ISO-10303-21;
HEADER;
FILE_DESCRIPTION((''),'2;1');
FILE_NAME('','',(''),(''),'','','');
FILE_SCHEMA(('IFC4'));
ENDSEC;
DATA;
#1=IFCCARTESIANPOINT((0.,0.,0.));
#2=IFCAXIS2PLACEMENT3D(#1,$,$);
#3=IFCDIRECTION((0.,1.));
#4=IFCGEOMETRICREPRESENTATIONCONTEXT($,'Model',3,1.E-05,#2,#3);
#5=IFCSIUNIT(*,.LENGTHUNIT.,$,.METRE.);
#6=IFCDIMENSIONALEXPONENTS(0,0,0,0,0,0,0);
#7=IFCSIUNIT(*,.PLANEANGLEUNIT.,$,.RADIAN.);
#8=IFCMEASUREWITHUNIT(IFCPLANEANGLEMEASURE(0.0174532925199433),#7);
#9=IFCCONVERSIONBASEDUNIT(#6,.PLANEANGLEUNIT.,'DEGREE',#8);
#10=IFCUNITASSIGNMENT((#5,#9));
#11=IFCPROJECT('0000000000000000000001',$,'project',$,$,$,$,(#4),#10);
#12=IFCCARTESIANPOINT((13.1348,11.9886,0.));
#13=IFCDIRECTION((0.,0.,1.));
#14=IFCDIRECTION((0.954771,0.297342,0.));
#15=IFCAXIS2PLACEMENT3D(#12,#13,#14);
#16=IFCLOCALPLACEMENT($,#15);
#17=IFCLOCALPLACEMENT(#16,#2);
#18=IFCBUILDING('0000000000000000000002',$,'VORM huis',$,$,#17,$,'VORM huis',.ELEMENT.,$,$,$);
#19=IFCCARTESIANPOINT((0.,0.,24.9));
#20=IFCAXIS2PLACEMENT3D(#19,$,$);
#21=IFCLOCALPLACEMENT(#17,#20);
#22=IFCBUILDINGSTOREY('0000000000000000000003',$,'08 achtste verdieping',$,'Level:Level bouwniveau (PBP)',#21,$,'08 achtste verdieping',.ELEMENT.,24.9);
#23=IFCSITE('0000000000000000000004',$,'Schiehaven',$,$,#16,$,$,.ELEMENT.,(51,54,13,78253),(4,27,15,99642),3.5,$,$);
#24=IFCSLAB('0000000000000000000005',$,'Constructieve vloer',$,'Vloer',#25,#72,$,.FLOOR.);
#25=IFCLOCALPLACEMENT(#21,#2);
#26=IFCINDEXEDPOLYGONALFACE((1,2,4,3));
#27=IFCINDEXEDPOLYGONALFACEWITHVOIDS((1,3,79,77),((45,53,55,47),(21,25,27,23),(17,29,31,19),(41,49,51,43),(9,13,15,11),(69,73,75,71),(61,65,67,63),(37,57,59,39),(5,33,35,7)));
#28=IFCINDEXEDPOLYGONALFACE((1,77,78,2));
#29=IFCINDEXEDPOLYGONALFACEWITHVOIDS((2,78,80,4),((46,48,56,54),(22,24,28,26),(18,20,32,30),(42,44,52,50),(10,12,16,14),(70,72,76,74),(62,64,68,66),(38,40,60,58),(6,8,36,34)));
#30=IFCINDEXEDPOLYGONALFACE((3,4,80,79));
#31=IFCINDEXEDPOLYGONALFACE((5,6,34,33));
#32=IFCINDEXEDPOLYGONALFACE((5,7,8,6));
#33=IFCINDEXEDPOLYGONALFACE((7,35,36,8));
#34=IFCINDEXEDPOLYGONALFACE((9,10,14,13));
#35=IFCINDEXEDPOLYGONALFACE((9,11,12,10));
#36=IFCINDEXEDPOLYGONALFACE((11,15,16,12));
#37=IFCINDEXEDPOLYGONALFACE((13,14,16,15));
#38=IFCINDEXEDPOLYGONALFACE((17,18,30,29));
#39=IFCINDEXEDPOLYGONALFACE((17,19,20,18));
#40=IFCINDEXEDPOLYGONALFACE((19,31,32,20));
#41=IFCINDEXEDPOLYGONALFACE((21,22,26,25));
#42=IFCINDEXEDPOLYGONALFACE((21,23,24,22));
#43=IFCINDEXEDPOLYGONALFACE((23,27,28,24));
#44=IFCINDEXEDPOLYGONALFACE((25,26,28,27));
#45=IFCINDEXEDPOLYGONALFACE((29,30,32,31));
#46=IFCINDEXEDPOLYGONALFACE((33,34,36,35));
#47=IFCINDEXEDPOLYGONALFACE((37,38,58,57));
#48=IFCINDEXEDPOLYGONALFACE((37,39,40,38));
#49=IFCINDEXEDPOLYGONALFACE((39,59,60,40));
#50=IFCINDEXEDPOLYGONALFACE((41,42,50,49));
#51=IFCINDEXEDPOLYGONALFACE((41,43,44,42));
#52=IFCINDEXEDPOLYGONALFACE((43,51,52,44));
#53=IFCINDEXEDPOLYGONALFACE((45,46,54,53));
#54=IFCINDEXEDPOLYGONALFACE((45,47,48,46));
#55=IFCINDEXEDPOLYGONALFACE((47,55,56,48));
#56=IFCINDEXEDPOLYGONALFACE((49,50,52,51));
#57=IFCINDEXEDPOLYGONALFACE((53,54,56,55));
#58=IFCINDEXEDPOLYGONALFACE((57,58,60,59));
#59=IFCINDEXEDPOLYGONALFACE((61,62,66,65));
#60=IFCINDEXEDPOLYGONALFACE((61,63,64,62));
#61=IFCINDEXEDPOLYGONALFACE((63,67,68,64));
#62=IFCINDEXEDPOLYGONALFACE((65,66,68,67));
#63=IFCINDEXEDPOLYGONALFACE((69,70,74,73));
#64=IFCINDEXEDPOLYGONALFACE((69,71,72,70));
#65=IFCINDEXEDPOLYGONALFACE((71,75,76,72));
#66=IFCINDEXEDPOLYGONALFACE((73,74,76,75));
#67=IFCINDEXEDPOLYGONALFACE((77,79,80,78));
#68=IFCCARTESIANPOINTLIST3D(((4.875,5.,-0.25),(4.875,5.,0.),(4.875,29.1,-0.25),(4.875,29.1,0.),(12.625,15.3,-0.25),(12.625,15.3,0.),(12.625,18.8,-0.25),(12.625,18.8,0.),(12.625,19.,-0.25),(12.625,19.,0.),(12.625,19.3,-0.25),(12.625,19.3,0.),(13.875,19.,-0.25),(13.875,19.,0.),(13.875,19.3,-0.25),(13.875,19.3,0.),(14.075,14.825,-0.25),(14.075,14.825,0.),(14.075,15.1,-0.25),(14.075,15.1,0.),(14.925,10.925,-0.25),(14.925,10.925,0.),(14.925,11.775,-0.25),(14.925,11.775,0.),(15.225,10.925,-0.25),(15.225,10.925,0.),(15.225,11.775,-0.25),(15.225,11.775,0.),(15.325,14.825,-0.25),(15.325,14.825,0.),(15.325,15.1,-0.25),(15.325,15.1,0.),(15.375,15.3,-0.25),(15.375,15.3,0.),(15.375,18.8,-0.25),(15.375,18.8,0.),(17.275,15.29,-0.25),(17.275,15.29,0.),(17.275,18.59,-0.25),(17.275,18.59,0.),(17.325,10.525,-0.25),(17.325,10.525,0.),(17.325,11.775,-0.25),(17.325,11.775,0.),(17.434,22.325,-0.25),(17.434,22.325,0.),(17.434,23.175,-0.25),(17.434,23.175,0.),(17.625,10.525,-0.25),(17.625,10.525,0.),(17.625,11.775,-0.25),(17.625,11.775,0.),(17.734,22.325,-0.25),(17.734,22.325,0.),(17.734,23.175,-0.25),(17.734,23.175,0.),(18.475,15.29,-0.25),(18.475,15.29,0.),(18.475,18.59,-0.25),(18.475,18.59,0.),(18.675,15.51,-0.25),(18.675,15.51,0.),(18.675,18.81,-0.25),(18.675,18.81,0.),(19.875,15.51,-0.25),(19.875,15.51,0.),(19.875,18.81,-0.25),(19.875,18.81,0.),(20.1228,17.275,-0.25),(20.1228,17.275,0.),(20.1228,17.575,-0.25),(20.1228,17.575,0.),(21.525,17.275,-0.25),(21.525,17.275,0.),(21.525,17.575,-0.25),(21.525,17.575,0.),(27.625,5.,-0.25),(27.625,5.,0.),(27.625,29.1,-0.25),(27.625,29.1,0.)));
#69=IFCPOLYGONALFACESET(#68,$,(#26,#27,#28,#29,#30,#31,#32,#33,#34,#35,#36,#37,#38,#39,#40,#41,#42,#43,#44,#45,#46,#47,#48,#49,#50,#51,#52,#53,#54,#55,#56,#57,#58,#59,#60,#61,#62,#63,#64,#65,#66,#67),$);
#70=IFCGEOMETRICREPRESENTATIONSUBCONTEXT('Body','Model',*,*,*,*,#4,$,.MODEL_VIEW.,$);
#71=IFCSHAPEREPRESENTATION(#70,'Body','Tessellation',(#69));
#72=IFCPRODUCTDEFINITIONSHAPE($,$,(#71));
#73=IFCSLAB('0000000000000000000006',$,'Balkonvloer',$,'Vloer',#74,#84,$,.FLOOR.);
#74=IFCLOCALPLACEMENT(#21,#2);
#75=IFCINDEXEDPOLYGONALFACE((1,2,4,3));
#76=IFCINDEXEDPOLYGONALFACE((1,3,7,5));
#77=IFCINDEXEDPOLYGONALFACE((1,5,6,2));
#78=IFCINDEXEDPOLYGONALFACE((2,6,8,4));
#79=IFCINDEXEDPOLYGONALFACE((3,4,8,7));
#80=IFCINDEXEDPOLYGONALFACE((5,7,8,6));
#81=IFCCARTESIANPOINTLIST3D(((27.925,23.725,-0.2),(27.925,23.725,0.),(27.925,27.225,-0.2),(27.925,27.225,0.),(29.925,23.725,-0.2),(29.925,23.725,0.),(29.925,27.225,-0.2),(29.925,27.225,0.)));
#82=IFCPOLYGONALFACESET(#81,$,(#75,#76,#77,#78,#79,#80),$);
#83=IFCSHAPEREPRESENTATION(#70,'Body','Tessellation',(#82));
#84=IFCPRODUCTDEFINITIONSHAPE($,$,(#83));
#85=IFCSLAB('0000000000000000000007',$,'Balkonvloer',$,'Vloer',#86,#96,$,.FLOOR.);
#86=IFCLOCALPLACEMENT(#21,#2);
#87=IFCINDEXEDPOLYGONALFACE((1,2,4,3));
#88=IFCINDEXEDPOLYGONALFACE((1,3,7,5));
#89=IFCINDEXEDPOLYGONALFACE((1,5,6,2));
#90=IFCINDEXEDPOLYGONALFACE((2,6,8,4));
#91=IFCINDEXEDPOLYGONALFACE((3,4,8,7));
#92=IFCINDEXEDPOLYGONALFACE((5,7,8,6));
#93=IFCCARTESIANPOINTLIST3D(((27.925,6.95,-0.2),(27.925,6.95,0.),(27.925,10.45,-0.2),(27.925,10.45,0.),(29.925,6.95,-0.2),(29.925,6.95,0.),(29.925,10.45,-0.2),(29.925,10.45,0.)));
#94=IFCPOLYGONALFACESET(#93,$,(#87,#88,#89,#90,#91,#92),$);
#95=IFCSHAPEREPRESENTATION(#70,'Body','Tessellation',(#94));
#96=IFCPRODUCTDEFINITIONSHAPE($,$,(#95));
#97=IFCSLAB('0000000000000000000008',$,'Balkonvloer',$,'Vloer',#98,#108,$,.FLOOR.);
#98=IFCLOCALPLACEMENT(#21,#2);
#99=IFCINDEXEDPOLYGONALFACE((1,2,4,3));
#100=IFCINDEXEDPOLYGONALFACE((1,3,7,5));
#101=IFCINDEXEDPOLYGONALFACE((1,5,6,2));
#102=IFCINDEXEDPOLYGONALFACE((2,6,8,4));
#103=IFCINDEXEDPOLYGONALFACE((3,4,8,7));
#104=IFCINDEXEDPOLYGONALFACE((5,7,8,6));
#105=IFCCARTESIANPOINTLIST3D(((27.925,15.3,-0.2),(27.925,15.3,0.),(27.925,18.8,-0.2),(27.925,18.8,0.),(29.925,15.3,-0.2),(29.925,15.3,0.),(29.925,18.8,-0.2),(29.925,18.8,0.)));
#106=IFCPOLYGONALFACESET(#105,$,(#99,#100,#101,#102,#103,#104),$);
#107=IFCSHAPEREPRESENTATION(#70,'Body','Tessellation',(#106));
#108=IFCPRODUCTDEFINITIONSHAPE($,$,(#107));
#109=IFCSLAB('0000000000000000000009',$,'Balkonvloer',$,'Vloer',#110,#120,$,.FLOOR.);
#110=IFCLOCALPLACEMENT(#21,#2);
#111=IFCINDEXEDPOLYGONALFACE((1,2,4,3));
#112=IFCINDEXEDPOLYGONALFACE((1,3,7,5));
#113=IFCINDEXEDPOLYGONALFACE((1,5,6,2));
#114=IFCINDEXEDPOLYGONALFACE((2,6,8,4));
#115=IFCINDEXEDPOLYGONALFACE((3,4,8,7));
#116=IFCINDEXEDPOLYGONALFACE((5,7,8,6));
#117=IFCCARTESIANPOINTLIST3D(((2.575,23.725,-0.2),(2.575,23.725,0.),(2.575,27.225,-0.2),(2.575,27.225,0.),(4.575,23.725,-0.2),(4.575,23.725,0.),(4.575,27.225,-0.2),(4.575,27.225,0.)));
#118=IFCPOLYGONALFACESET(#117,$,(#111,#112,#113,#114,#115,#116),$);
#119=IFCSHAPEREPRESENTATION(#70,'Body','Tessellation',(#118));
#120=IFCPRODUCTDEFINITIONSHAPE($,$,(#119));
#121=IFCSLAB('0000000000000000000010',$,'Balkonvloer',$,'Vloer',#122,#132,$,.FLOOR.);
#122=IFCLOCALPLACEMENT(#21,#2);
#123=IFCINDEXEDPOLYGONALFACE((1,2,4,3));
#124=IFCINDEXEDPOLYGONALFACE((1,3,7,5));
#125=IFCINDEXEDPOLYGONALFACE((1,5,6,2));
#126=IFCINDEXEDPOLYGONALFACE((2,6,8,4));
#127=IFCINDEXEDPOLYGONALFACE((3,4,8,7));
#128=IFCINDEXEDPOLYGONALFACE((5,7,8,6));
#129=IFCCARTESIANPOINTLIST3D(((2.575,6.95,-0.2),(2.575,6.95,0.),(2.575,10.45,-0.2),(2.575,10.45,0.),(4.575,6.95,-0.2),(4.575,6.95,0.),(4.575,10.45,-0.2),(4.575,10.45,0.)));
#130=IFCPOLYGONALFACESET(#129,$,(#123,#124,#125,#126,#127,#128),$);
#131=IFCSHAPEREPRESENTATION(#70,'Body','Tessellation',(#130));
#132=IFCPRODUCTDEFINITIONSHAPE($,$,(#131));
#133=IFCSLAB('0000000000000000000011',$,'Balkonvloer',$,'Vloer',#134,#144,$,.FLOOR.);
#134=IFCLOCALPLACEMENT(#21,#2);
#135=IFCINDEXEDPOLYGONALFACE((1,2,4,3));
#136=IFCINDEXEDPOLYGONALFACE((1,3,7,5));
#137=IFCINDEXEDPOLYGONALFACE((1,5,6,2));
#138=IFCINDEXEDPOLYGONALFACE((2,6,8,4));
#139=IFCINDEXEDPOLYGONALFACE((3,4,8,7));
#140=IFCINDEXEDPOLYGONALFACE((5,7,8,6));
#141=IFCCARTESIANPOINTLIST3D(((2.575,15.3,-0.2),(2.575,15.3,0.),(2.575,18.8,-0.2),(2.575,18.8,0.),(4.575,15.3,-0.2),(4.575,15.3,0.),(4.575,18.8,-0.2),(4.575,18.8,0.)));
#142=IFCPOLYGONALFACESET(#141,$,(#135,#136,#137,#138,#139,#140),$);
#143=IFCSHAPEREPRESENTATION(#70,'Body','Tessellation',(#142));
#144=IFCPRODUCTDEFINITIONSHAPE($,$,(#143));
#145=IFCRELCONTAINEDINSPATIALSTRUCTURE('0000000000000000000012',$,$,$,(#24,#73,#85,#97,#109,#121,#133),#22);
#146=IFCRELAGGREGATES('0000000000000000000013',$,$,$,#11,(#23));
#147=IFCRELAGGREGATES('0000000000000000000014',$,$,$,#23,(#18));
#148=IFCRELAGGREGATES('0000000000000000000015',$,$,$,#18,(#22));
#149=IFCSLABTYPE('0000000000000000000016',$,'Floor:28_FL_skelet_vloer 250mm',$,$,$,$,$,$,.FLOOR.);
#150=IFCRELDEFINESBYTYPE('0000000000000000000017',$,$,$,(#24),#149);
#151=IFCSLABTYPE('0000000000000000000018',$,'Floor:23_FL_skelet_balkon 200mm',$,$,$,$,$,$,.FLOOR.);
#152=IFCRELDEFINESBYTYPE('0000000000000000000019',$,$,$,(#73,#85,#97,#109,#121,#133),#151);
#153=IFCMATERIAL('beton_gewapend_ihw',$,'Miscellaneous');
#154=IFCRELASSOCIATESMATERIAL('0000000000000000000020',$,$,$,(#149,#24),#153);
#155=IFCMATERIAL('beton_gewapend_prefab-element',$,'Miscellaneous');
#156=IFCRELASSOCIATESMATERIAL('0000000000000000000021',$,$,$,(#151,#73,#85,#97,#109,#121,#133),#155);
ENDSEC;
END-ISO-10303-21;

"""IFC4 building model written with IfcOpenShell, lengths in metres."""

from ifc_helpers import new_model, entity, si_unit, converted_unit, direction, frame, origin, place, context, subcontext, project, spatial, indexed_curve, outline, extrude, material, type_object, element, save


model = new_model("IFC4")

# Units and contexts
model_context = context("Model", 3, precision=1e-05, world=origin(), true_north=direction((0.0, 1.0)))
body_context = subcontext(model_context, "Body", "Model", "MODEL_VIEW")
ifc_project = project(units=[si_unit("LENGTHUNIT", "METRE"), converted_unit("PLANEANGLEUNIT", "DEGREE", entity("IfcPlaneAngleMeasure", 0.0174532925199433), si_unit("PLANEANGLEUNIT", "RADIAN"), dimensions=[0, 0, 0, 0, 0, 0, 0])], contexts=[model_context])

# Site, building, storey
site_placement = place(None, frame((13.1348, 11.9886, 0.0), z_axis=(0.0, 0.0, 1.0), x_axis=(0.954771, 0.297342, 0.0)))
site = spatial("IfcSite", under=ifc_project, at=site_placement, Name="Schiehaven", CompositionType="ELEMENT", RefLatitude=(51, 54, 13, 78253), RefLongitude=(4, 27, 15, 99642), RefElevation=3.5)
building_placement = place(site_placement, origin())
building = spatial("IfcBuilding", under=site, at=building_placement, Name="VORM huis", LongName="VORM huis", CompositionType="ELEMENT")
storey_placement = place(building_placement, frame((0.0, 0.0, 24.9)))
storey = spatial("IfcBuildingStorey", under=building, at=storey_placement, Name="08 achtste verdieping", ObjectType="Level:Level bouwniveau (PBP)", LongName="08 achtste verdieping", CompositionType="ELEMENT", Elevation=24.9)

# Slab, openings
ifc_material_1 = material(Name="beton_gewapend_ihw", Category="Miscellaneous")
slab_type_1 = type_object("IfcSlabType", Name="Floor:28_FL_skelet_vloer 250mm", PredefinedType="FLOOR", material=ifc_material_1)
slab_1_placement = place(storey_placement, origin())
slab_1 = element("IfcSlab", 1, at=slab_1_placement, inside=storey, type_object=slab_type_1, material=ifc_material_1, Name="Constructieve vloer", ObjectType="Vloer", PredefinedType="FLOOR", context=body_context, shape_type="SweptSolid", body=[
    extrude(outline(indexed_curve([(-12.05, -11.375), (12.05, -11.375), (12.05, 11.375), (-12.05, 11.375), (-12.05, -11.375)], self_intersect=False), holes=[indexed_curve([(-1.75, -3.625), (-1.75, -0.875), (1.75, -0.875), (1.75, -3.625), (-1.75, -3.625)], self_intersect=False), indexed_curve([(1.76, 2.225), (1.76, 1.025), (-1.54, 1.025), (-1.54, 2.225), (1.76, 2.225)], self_intersect=False), indexed_curve([(-1.76, 3.625), (1.54, 3.625), (1.54, 2.425), (-1.76, 2.425), (-1.76, 3.625)], self_intersect=False), indexed_curve([(5.275, -1.025), (6.125, -1.025), (6.125, -1.325), (5.275, -1.325), (5.275, -1.025)], self_intersect=False), indexed_curve([(5.275, 1.375), (6.525, 1.375), (6.525, 1.075), (5.275, 1.075), (5.275, 1.375)], self_intersect=False), indexed_curve([(-0.525, 5.275), (-0.225, 5.275), (-0.225, 3.8728), (-0.525, 3.8728), (-0.525, 5.275)], self_intersect=False), indexed_curve([(-6.125, 1.484), (-5.275, 1.484), (-5.275, 1.184), (-6.125, 1.184), (-6.125, 1.484)], self_intersect=False), indexed_curve([(1.95, -0.925), (2.225, -0.925), (2.225, -2.175), (1.95, -2.175), (1.95, -0.925)], self_intersect=False), indexed_curve([(-2.25, -2.375), (-1.95, -2.375), (-1.95, -3.625), (-2.25, -3.625), (-2.25, -2.375)], self_intersect=False)]), frame((16.25, 17.05, -0.25), z_axis=(0.0, 0.0, 1.0), x_axis=(0.0, -1.0, 0.0)), (0.0, 0.0, 1.0), 0.25),
])
opening_1_placement = place(slab_1_placement, origin())
element("IfcOpeningElement", 2, at=opening_1_placement, cuts=slab_1, PredefinedType="OPENING", context=body_context, shape_type="SweptSolid", body=[
    extrude(outline(indexed_curve([(-1.75, -1.375), (1.75, -1.375), (1.75, 1.375), (-1.75, 1.375), (-1.75, -1.375)], self_intersect=False)), frame((14.0, 17.05, -0.25), z_axis=(0.0, 0.0, 1.0), x_axis=(0.0, -1.0, 0.0)), (0.0, 0.0, 1.0), 0.25),
])
opening_2_placement = place(slab_1_placement, origin())
element("IfcOpeningElement", 3, at=opening_2_placement, cuts=slab_1, PredefinedType="OPENING", context=body_context, shape_type="SweptSolid", body=[
    extrude(outline(indexed_curve([(-1.65, -0.6), (1.65, -0.6), (1.65, 0.6), (-1.65, 0.6), (-1.65, -0.6)], self_intersect=False)), frame((17.875, 16.94, -0.25), z_axis=(0.0, 0.0, 1.0), x_axis=(0.0, 1.0, 0.0)), (0.0, 0.0, 1.0), 0.25),
])
opening_3_placement = place(slab_1_placement, origin())
element("IfcOpeningElement", 4, at=opening_3_placement, cuts=slab_1, PredefinedType="OPENING", context=body_context, shape_type="SweptSolid", body=[
    extrude(outline(indexed_curve([(-0.15, -0.425), (0.15, -0.425), (0.15, 0.425), (-0.15, 0.425), (-0.15, -0.425)], self_intersect=False)), frame((15.075, 11.35, -0.25), z_axis=(0.0, 0.0, 1.0), x_axis=(-1.0, 0.0, 0.0)), (0.0, 0.0, 1.0), 0.25),
])
opening_4_placement = place(slab_1_placement, origin())
element("IfcOpeningElement", 5, at=opening_4_placement, cuts=slab_1, PredefinedType="OPENING", context=body_context, shape_type="SweptSolid", body=[
    extrude(outline(indexed_curve([(-0.15, -0.625), (0.15, -0.625), (0.15, 0.625), (-0.15, 0.625), (-0.15, -0.625)], self_intersect=False)), frame((17.475, 11.15, -0.25), z_axis=(0.0, 0.0, 1.0), x_axis=(-1.0, 0.0, 0.0)), (0.0, 0.0, 1.0), 0.25),
])
opening_5_placement = place(slab_1_placement, origin())
element("IfcOpeningElement", 6, at=opening_5_placement, cuts=slab_1, PredefinedType="OPENING", context=body_context, shape_type="SweptSolid", body=[
    extrude(outline(indexed_curve([(-0.7011, -0.15), (0.7011, -0.15), (0.7011, 0.15), (-0.7011, 0.15), (-0.7011, -0.15)], self_intersect=False)), frame((20.8239, 17.425, -0.25), z_axis=(0.0, 0.0, 1.0), x_axis=(-1.0, 0.0, 0.0)), (0.0, 0.0, 1.0), 0.25),
])
opening_6_placement = place(slab_1_placement, origin())
element("IfcOpeningElement", 7, at=opening_6_placement, cuts=slab_1, PredefinedType="OPENING", context=body_context, shape_type="SweptSolid", body=[
    extrude(outline(indexed_curve([(-0.15, -0.425), (0.15, -0.425), (0.15, 0.425), (-0.15, 0.425), (-0.15, -0.425)], self_intersect=False)), frame((17.584, 22.75, -0.25), z_axis=(0.0, 0.0, 1.0), x_axis=(-1.0, 0.0, 0.0)), (0.0, 0.0, 1.0), 0.25),
])
opening_7_placement = place(slab_1_placement, origin())
element("IfcOpeningElement", 8, at=opening_7_placement, cuts=slab_1, PredefinedType="OPENING", context=body_context, shape_type="SweptSolid", body=[
    extrude(outline(indexed_curve([(-0.625, -0.1375), (0.625, -0.1375), (0.625, 0.1375), (-0.625, 0.1375), (-0.625, -0.1375)], self_intersect=False)), frame((14.7, 14.9625, -0.25), z_axis=(0.0, 0.0, 1.0), x_axis=(-1.0, 0.0, 0.0)), (0.0, 0.0, 1.0), 0.25),
])
opening_8_placement = place(slab_1_placement, origin())
element("IfcOpeningElement", 9, at=opening_8_placement, cuts=slab_1, PredefinedType="OPENING", context=body_context, shape_type="SweptSolid", body=[
    extrude(outline(indexed_curve([(-0.625, -0.15), (0.625, -0.15), (0.625, 0.15), (-0.625, 0.15), (-0.625, -0.15)], self_intersect=False)), frame((13.25, 19.15, -0.25), z_axis=(0.0, 0.0, 1.0), x_axis=(-1.0, 0.0, 0.0)), (0.0, 0.0, 1.0), 0.25),
])

# Slabs
ifc_material_2 = material(Name="beton_gewapend_prefab-element", Category="Miscellaneous")
slab_type_2 = type_object("IfcSlabType", Name="Floor:23_FL_skelet_balkon 200mm", PredefinedType="FLOOR", material=ifc_material_2)
slab_2_placement = place(storey_placement, origin())
element("IfcSlab", 10, at=slab_2_placement, inside=storey, type_object=slab_type_2, material=ifc_material_2, Name="Balkonvloer", ObjectType="Vloer", PredefinedType="FLOOR", context=body_context, shape_type="SweptSolid", body=[
    extrude(outline(indexed_curve([(-1.75, -1.0), (1.75, -1.0), (1.75, 1.0), (-1.75, 1.0), (-1.75, -1.0)], self_intersect=False)), frame((28.925, 25.475, 0.0), z_axis=(0.0, 0.0, -1.0), x_axis=(0.0, 1.0, 0.0)), (0.0, 0.0, 1.0), 0.2),
])
slab_3_placement = place(storey_placement, origin())
element("IfcSlab", 11, at=slab_3_placement, inside=storey, type_object=slab_type_2, material=ifc_material_2, Name="Balkonvloer", ObjectType="Vloer", PredefinedType="FLOOR", context=body_context, shape_type="SweptSolid", body=[
    extrude(outline(indexed_curve([(-1.75, -1.0), (1.75, -1.0), (1.75, 1.0), (-1.75, 1.0), (-1.75, -1.0)], self_intersect=False)), frame((28.925, 8.7, 0.0), z_axis=(0.0, 0.0, -1.0), x_axis=(0.0, 1.0, 0.0)), (0.0, 0.0, 1.0), 0.2),
])
slab_4_placement = place(storey_placement, origin())
element("IfcSlab", 12, at=slab_4_placement, inside=storey, type_object=slab_type_2, material=ifc_material_2, Name="Balkonvloer", ObjectType="Vloer", PredefinedType="FLOOR", context=body_context, shape_type="SweptSolid", body=[
    extrude(outline(indexed_curve([(-1.75, -1.0), (1.75, -1.0), (1.75, 1.0), (-1.75, 1.0), (-1.75, -1.0)], self_intersect=False)), frame((28.925, 17.05, 0.0), z_axis=(0.0, 0.0, -1.0), x_axis=(0.0, 1.0, 0.0)), (0.0, 0.0, 1.0), 0.2),
])
slab_5_placement = place(storey_placement, origin())
element("IfcSlab", 13, at=slab_5_placement, inside=storey, type_object=slab_type_2, material=ifc_material_2, Name="Balkonvloer", ObjectType="Vloer", PredefinedType="FLOOR", context=body_context, shape_type="SweptSolid", body=[
    extrude(outline(indexed_curve([(-1.75, -1.0), (1.75, -1.0), (1.75, 1.0), (-1.75, 1.0), (-1.75, -1.0)], self_intersect=False)), frame((3.575, 25.475, 0.0), z_axis=(0.0, 0.0, -1.0), x_axis=(0.0, 1.0, 0.0)), (0.0, 0.0, 1.0), 0.2),
])
slab_6_placement = place(storey_placement, origin())
element("IfcSlab", 14, at=slab_6_placement, inside=storey, type_object=slab_type_2, material=ifc_material_2, Name="Balkonvloer", ObjectType="Vloer", PredefinedType="FLOOR", context=body_context, shape_type="SweptSolid", body=[
    extrude(outline(indexed_curve([(-1.75, -1.0), (1.75, -1.0), (1.75, 1.0), (-1.75, 1.0), (-1.75, -1.0)], self_intersect=False)), frame((3.575, 8.7, 0.0), z_axis=(0.0, 0.0, -1.0), x_axis=(0.0, 1.0, 0.0)), (0.0, 0.0, 1.0), 0.2),
])
slab_7_placement = place(storey_placement, origin())
element("IfcSlab", 15, at=slab_7_placement, inside=storey, type_object=slab_type_2, material=ifc_material_2, Name="Balkonvloer", ObjectType="Vloer", PredefinedType="FLOOR", context=body_context, shape_type="SweptSolid", body=[
    extrude(outline(indexed_curve([(-1.75, -1.0), (1.75, -1.0), (1.75, 1.0), (-1.75, 1.0), (-1.75, -1.0)], self_intersect=False)), frame((3.575, 17.05, 0.0), z_axis=(0.0, 0.0, -1.0), x_axis=(0.0, 1.0, 0.0)), (0.0, 0.0, 1.0), 0.2),
])

save(model, "model.ifc")
